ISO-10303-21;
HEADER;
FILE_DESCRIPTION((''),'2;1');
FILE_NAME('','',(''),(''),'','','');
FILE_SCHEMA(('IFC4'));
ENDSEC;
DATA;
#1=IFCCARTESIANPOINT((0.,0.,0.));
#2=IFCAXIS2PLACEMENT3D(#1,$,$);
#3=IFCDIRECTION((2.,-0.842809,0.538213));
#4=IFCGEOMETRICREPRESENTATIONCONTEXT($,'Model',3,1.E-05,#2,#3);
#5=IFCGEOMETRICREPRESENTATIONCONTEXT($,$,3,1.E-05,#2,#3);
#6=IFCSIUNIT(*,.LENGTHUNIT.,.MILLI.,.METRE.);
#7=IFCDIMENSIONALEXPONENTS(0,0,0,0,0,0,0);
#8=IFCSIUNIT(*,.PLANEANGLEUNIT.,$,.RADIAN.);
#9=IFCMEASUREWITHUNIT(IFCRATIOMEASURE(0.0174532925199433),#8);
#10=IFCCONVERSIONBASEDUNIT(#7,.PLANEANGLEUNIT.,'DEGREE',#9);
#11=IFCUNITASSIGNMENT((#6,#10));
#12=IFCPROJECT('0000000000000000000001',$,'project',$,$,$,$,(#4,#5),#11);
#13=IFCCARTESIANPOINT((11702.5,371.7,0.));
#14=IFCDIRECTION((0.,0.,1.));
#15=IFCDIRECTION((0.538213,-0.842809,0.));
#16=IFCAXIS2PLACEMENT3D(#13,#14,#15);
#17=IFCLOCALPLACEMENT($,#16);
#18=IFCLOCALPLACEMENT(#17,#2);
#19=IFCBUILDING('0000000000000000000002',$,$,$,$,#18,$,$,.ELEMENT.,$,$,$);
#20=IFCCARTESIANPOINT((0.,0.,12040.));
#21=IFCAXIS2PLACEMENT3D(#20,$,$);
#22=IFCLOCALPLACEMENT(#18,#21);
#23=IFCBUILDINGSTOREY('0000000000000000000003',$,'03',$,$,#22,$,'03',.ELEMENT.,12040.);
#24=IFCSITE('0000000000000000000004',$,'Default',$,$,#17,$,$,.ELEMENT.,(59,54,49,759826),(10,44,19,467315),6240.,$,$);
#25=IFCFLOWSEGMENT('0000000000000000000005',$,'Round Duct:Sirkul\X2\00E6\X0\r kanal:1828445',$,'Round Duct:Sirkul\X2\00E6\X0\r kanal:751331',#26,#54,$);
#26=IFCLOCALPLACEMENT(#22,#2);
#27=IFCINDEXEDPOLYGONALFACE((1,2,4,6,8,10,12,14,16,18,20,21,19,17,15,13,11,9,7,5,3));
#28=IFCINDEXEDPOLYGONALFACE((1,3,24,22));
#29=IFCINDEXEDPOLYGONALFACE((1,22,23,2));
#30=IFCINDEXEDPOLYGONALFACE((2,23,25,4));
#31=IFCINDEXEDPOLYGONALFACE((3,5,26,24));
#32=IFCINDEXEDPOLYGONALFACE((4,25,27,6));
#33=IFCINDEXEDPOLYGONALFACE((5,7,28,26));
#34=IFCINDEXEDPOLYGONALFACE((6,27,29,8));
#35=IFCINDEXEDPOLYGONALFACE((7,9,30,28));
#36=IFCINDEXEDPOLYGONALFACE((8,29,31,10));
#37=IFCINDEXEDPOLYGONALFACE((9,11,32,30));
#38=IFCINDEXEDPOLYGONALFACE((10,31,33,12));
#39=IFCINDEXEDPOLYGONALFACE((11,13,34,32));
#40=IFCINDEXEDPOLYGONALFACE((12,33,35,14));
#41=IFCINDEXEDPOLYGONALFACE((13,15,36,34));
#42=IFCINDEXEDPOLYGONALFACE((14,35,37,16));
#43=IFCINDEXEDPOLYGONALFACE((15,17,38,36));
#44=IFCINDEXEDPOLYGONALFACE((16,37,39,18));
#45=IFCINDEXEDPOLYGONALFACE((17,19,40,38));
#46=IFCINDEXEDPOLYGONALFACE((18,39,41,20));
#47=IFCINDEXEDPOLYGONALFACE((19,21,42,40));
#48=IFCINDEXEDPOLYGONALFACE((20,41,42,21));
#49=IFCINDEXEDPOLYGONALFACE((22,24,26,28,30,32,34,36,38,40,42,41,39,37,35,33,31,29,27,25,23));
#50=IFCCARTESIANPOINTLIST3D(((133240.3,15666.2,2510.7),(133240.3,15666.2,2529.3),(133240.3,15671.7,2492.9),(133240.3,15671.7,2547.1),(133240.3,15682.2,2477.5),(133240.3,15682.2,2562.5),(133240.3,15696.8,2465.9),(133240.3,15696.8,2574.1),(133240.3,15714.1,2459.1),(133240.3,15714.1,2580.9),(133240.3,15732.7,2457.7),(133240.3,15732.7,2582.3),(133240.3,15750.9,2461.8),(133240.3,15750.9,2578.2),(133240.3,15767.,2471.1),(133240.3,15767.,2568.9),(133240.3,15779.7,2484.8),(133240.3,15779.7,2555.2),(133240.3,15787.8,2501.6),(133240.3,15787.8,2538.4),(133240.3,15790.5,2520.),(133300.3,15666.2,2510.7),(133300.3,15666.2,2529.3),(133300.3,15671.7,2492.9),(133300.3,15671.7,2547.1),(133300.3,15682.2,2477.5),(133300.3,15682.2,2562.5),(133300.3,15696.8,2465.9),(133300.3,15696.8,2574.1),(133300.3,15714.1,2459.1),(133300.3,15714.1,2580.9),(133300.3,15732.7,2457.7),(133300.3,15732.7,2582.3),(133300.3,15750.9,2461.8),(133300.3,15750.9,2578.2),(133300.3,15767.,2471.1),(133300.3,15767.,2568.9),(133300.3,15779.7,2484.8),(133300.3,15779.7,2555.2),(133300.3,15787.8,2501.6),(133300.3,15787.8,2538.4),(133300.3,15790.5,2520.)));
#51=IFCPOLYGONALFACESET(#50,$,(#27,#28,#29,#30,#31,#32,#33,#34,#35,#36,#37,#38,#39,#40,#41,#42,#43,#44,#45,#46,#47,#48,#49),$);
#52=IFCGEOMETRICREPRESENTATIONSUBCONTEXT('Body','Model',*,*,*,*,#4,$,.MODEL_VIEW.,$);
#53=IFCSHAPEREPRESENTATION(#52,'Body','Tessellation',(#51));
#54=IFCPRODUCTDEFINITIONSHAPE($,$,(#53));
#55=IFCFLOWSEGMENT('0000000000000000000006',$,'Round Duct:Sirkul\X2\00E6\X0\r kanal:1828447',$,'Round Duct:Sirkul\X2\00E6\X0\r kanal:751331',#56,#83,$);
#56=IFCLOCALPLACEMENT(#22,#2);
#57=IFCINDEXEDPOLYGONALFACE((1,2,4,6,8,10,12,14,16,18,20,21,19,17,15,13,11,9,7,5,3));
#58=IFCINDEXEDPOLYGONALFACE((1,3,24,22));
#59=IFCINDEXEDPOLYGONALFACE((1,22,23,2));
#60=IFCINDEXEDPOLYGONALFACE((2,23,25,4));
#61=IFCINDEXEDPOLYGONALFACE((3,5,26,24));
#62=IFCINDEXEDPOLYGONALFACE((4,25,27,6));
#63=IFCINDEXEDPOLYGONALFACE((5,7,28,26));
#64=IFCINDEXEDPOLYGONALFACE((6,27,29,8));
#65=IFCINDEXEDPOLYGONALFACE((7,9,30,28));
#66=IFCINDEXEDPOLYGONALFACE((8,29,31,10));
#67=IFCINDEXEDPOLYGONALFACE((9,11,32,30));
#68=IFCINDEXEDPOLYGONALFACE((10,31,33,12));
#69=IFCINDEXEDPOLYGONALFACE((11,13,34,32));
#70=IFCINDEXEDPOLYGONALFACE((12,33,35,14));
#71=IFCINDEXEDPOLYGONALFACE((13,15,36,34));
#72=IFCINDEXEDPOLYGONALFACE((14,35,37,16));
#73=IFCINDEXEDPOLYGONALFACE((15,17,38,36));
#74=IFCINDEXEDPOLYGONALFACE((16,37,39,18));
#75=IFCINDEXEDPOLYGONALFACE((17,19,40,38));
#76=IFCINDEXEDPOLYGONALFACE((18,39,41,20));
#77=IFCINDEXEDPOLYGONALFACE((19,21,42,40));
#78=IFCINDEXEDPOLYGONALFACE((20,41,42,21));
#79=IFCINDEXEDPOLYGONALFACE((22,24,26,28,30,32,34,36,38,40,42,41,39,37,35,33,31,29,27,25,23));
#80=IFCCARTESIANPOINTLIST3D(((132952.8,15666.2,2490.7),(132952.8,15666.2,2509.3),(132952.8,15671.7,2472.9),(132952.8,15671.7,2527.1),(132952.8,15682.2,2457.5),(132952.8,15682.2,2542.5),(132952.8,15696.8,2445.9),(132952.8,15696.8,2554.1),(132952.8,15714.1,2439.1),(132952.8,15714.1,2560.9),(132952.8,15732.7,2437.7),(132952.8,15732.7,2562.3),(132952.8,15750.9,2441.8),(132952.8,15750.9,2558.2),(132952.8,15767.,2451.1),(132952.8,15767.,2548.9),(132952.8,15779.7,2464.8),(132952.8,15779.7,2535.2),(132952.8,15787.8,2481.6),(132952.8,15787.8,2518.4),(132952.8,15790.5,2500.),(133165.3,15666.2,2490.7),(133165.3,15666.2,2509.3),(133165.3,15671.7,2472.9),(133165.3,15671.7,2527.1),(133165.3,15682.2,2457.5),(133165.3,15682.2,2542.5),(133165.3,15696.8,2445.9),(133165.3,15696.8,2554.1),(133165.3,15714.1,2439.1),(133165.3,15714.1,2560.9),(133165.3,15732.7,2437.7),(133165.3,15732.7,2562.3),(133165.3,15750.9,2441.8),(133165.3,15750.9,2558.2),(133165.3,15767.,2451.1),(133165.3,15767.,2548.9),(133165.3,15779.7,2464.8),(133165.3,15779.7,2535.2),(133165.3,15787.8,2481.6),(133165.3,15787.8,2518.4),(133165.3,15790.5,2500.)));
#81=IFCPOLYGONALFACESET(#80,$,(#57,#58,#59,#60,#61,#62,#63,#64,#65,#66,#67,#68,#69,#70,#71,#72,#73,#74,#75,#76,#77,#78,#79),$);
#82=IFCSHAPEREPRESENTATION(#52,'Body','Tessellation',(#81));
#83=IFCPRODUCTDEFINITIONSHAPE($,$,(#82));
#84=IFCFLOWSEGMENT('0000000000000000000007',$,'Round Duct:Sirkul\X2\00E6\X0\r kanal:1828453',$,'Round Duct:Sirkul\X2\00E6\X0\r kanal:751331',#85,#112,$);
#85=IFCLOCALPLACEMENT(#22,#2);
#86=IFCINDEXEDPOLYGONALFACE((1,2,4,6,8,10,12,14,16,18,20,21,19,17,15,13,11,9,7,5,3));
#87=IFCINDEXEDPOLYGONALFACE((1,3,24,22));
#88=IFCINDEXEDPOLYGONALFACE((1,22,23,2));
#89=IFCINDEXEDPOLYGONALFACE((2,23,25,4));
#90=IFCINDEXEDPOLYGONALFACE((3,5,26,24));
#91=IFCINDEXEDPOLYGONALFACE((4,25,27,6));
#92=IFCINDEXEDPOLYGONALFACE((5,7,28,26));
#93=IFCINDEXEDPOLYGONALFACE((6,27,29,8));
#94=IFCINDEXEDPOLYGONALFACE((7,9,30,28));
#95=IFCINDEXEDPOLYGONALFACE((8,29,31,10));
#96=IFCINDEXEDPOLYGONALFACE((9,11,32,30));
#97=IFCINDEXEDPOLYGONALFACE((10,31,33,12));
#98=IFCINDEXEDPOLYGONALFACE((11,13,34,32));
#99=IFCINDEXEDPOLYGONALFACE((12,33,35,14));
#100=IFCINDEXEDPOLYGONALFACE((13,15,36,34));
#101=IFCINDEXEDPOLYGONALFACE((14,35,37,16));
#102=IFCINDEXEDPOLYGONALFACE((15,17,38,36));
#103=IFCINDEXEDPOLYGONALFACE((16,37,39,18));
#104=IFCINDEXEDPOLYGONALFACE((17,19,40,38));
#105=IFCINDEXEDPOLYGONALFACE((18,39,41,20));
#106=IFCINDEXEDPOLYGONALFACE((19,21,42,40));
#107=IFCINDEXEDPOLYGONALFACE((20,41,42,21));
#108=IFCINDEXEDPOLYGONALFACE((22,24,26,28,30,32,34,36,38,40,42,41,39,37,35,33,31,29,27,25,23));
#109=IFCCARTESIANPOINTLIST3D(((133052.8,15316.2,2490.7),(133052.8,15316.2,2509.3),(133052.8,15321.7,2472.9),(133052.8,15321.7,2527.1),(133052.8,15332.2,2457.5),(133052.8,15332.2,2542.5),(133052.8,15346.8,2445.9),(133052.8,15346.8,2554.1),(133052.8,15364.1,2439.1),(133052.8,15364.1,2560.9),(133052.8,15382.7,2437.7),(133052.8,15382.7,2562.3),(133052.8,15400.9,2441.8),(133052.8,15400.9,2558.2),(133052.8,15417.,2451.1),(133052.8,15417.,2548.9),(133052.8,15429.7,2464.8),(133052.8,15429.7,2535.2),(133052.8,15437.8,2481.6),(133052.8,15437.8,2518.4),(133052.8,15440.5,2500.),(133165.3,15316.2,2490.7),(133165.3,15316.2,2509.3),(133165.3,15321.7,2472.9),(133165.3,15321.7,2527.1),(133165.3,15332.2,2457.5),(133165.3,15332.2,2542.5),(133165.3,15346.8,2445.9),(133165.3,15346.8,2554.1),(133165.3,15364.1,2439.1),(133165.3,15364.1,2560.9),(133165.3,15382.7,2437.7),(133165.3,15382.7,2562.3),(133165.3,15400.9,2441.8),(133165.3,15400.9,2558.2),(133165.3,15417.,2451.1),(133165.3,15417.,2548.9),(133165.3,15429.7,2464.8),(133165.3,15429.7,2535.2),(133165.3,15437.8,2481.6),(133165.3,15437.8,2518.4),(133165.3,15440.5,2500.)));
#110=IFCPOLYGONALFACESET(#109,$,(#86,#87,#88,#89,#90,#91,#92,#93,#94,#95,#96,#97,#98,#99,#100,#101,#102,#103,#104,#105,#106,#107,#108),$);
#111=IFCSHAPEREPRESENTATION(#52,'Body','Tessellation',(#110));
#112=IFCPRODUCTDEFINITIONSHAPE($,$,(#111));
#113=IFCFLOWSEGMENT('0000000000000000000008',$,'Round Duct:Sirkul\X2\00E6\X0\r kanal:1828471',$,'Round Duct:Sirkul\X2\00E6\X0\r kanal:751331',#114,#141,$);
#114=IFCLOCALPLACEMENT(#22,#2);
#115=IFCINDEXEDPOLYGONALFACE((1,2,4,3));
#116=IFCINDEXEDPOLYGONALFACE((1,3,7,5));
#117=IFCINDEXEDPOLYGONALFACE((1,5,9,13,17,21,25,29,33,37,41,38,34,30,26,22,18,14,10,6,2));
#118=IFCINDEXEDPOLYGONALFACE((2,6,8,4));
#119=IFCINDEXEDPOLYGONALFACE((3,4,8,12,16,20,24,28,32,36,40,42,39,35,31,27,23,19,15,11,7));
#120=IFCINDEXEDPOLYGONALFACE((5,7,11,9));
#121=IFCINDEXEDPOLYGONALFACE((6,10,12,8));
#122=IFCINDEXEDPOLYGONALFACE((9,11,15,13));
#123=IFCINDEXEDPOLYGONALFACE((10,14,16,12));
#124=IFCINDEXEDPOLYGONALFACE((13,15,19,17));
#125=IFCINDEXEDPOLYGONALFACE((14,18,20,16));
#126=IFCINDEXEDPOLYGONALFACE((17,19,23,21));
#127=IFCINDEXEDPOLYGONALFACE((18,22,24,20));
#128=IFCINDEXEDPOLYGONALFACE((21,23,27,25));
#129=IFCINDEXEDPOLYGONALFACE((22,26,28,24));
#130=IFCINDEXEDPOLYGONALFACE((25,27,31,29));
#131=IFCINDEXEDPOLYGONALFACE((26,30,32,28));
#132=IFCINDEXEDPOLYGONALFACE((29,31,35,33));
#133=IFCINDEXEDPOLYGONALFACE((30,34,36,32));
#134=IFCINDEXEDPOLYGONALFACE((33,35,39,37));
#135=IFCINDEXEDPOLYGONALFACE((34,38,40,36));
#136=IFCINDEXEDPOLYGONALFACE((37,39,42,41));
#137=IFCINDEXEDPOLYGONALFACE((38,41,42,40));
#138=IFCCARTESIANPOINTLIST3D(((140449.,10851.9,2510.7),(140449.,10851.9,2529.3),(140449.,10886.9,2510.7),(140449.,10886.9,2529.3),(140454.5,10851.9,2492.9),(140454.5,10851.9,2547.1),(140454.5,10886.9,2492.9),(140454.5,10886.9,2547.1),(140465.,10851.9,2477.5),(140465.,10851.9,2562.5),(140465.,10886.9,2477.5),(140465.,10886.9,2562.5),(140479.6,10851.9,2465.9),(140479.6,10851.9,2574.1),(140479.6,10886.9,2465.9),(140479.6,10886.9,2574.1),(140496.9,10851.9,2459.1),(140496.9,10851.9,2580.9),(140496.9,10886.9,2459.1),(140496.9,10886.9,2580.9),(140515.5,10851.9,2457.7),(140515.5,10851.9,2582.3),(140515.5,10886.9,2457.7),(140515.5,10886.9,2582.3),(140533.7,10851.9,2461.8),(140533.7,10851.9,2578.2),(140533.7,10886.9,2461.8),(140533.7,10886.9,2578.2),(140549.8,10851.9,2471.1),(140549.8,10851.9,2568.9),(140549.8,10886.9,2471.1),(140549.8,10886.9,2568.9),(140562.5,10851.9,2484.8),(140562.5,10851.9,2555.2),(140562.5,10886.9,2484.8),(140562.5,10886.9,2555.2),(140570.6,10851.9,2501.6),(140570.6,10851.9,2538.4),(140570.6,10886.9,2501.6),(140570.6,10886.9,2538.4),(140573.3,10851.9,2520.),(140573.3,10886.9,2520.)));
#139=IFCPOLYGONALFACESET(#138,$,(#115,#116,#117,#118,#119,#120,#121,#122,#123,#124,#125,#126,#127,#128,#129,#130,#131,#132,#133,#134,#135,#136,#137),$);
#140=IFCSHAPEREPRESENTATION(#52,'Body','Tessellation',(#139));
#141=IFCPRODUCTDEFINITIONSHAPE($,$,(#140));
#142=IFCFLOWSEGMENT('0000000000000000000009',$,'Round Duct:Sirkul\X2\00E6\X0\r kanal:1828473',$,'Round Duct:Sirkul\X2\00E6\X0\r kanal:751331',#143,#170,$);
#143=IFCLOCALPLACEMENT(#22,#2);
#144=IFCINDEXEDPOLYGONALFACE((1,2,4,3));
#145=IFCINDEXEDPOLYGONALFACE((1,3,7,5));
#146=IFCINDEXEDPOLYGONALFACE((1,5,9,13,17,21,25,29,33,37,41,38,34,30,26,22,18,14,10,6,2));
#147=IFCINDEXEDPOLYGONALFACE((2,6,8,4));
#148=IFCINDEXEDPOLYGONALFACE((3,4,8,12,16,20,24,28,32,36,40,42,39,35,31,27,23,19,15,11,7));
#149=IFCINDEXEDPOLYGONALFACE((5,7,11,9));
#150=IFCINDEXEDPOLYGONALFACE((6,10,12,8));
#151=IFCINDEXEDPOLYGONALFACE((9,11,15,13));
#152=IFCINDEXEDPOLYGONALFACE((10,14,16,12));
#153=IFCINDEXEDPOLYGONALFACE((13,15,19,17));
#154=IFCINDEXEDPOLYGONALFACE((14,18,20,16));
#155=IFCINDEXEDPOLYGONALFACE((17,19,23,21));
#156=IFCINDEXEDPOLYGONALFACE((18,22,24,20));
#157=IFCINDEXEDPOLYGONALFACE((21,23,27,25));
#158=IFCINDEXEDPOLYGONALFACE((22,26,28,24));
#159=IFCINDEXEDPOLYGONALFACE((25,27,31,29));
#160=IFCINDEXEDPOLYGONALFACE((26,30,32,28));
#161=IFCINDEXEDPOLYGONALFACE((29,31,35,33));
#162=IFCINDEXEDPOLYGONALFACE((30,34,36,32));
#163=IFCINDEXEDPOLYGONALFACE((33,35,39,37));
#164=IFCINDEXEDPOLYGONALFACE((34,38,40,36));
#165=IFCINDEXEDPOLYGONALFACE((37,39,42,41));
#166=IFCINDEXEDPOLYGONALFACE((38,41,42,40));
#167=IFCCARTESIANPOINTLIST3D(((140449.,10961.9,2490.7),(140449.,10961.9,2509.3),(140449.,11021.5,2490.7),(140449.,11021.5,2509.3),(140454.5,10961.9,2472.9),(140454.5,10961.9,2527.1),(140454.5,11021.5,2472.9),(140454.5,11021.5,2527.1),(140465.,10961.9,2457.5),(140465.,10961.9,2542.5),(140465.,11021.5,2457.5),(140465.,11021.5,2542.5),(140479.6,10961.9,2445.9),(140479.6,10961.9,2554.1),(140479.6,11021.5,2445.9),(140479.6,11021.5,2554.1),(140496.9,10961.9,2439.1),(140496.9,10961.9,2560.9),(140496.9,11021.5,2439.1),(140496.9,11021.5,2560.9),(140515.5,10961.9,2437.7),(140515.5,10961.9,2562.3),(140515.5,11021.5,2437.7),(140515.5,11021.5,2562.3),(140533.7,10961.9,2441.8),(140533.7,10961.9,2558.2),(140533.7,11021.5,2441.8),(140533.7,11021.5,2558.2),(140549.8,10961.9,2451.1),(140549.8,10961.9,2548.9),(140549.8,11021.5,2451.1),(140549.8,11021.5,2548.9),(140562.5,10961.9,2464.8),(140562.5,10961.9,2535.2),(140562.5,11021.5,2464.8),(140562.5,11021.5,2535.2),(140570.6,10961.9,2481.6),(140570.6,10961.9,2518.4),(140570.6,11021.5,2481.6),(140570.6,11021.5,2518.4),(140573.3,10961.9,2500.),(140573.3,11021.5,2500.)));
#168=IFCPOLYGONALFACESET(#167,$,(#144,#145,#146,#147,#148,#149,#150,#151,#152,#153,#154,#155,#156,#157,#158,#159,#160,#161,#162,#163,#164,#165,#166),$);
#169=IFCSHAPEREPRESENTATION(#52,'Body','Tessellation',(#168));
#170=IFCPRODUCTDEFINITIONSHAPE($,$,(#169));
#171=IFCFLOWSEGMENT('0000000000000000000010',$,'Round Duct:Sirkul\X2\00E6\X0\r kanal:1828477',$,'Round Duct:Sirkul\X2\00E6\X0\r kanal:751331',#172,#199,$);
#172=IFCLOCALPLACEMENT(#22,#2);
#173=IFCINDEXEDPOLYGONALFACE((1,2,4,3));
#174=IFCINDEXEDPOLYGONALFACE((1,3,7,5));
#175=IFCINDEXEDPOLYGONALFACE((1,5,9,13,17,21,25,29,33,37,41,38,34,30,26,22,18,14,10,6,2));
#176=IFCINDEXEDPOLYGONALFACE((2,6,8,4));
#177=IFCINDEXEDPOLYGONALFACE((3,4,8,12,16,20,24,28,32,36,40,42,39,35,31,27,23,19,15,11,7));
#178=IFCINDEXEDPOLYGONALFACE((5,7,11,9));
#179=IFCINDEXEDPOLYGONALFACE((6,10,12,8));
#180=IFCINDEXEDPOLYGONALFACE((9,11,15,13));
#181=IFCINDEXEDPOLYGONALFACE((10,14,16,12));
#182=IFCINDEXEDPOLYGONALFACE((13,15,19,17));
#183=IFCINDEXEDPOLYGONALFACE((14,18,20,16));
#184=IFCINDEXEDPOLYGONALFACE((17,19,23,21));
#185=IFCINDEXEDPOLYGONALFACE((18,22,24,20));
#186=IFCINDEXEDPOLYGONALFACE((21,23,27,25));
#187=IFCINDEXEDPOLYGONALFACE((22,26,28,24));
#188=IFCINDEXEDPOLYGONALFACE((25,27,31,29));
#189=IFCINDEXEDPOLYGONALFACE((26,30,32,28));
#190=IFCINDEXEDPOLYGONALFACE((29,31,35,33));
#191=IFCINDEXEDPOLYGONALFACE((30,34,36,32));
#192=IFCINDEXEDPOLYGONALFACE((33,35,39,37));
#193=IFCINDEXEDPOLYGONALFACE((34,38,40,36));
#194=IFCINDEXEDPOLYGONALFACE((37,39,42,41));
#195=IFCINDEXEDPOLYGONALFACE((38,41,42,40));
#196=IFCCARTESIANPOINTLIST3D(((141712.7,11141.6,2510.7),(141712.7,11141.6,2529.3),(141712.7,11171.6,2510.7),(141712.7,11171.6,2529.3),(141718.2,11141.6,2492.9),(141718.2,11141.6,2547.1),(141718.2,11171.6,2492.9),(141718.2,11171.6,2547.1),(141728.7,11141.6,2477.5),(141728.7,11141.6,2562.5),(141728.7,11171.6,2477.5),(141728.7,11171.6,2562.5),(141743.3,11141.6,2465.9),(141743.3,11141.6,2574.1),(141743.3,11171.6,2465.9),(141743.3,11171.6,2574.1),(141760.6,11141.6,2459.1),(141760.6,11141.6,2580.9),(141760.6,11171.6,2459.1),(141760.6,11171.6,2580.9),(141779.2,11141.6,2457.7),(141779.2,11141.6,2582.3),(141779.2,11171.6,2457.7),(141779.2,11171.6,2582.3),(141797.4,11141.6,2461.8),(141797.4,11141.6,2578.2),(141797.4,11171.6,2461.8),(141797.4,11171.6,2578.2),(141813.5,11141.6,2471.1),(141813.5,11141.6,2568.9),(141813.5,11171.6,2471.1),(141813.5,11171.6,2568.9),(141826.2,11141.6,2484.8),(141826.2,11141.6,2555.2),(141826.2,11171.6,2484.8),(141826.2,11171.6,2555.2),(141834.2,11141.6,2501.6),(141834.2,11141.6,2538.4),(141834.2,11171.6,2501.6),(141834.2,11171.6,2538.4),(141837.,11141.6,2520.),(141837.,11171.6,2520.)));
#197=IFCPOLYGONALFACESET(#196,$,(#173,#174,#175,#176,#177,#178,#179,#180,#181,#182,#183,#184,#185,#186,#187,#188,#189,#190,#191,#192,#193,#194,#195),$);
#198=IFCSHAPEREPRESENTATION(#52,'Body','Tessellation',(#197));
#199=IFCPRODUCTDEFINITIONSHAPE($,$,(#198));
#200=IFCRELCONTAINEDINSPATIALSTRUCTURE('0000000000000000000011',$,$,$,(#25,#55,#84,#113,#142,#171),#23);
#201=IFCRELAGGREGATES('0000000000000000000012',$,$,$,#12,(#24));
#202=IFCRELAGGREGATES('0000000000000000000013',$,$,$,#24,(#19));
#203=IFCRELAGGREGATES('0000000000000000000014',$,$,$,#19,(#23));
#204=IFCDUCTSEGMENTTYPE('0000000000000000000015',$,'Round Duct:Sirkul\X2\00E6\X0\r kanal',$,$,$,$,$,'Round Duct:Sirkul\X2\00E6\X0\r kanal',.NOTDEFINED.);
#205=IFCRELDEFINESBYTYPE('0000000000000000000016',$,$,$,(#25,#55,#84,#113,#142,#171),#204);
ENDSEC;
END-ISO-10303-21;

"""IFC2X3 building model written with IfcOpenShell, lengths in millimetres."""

from ifc_helpers import new_model, entity, si_unit, converted_unit, direction, frame, frame_2d, origin, origin_2d_with_axis, place, context, subcontext, project, spatial, circle, extrude, type_object, element, save


model = new_model("IFC2X3")

# Units and contexts
model_context = context("Model", 3, precision=1e-05, world=origin(), true_north=direction((2.0, -0.842809, 0.538213)))
context_of_model = context(None, 3, precision=1e-05, world=origin(), true_north=direction((2.0, -0.842809, 0.538213)))
body_context = subcontext(model_context, "Body", "Model", "MODEL_VIEW")
ifc_project = project(units=[si_unit("LENGTHUNIT", "METRE", prefix="MILLI"), converted_unit("PLANEANGLEUNIT", "DEGREE", entity("IfcRatioMeasure", 0.0174532925199433), si_unit("PLANEANGLEUNIT", "RADIAN"), dimensions=[0, 0, 0, 0, 0, 0, 0])], contexts=[model_context, context_of_model])

# Site, building, storey
site_placement = place(None, frame((11702.5, 371.7, 0.0), z_axis=(0.0, 0.0, 1.0), x_axis=(0.538213, -0.842809, 0.0)))
site = spatial("IfcSite", under=ifc_project, at=site_placement, Name="Default", CompositionType="ELEMENT", RefLatitude=(59, 54, 49, 759826), RefLongitude=(10, 44, 19, 467315), RefElevation=6240.0)
building_placement = place(site_placement, origin())
building = spatial("IfcBuilding", under=site, at=building_placement, CompositionType="ELEMENT")
storey_placement = place(building_placement, frame((0.0, 0.0, 12040.0)))
storey = spatial("IfcBuildingStorey", under=building, at=storey_placement, Name="03", LongName="03", CompositionType="ELEMENT", Elevation=12040.0)

# Flow segments
duct_segment_type_1 = type_object("IfcDuctSegmentType", Name="Round Duct:Sirkulær kanal", ElementType="Round Duct:Sirkulær kanal", PredefinedType="NOTDEFINED")
flow_segment_1_placement = place(storey_placement, origin())
element("IfcFlowSegment", 1, at=flow_segment_1_placement, inside=storey, type_object=duct_segment_type_1, Name="Round Duct:Sirkulær kanal:1828445", ObjectType="Round Duct:Sirkulær kanal:751331", context=body_context, shape_type="SweptSolid", body=[
    extrude(circle(Radius=62.5, at=frame_2d((0.0, 0.0), x_axis=(1.0, 0.0))), frame((133240.3, 15728.0, 2520.0), z_axis=(1.0, 0.0, 0.0), x_axis=(0.0, 1.0, 0.0)), (0.0, 0.0, 1.0), 60.0),
])
flow_segment_2_placement = place(storey_placement, origin())
element("IfcFlowSegment", 2, at=flow_segment_2_placement, inside=storey, type_object=duct_segment_type_1, Name="Round Duct:Sirkulær kanal:1828447", ObjectType="Round Duct:Sirkulær kanal:751331", context=body_context, shape_type="SweptSolid", body=[
    extrude(circle(Radius=62.5, at=frame_2d((0.0, 0.0), x_axis=(1.0, 0.0))), frame((132952.8, 15728.0, 2500.0), z_axis=(1.0, 0.0, 0.0), x_axis=(0.0, 1.0, 0.0)), (0.0, 0.0, 1.0), 212.5),
])
flow_segment_3_placement = place(storey_placement, origin())
element("IfcFlowSegment", 3, at=flow_segment_3_placement, inside=storey, type_object=duct_segment_type_1, Name="Round Duct:Sirkulær kanal:1828453", ObjectType="Round Duct:Sirkulær kanal:751331", context=body_context, shape_type="SweptSolid", body=[
    extrude(circle(Radius=62.5, at=frame_2d((0.0, 0.0), x_axis=(1.0, 0.0))), frame((133052.8, 15378.0, 2500.0), z_axis=(1.0, 0.0, 0.0), x_axis=(0.0, 1.0, 0.0)), (0.0, 0.0, 1.0), 112.5),
])
flow_segment_4_placement = place(storey_placement, origin())
element("IfcFlowSegment", 4, at=flow_segment_4_placement, inside=storey, type_object=duct_segment_type_1, Name="Round Duct:Sirkulær kanal:1828471", ObjectType="Round Duct:Sirkulær kanal:751331", context=body_context, shape_type="SweptSolid", body=[
    extrude(circle(Radius=62.5, at=frame_2d((0.0, 0.0), x_axis=(1.0, 0.0))), frame((140510.8, 10851.9, 2520.0), z_axis=(0.0, 1.0, 0.0), x_axis=(1.0, 0.0, 0.0)), (0.0, 0.0, 1.0), 35.0),
])
flow_segment_5_placement = place(storey_placement, origin())
element("IfcFlowSegment", 5, at=flow_segment_5_placement, inside=storey, type_object=duct_segment_type_1, Name="Round Duct:Sirkulær kanal:1828473", ObjectType="Round Duct:Sirkulær kanal:751331", context=body_context, shape_type="SweptSolid", body=[
    extrude(circle(Radius=62.5, at=origin_2d_with_axis()), frame((140510.8, 10961.9, 2500.0), z_axis=(0.0, 1.0, 0.0), x_axis=(1.0, 0.0, 0.0)), (0.0, 0.0, 1.0), 59.6),
])
flow_segment_6_placement = place(storey_placement, origin())
element("IfcFlowSegment", 6, at=flow_segment_6_placement, inside=storey, type_object=duct_segment_type_1, Name="Round Duct:Sirkulær kanal:1828477", ObjectType="Round Duct:Sirkulær kanal:751331", context=body_context, shape_type="SweptSolid", body=[
    extrude(circle(Radius=62.5, at=frame_2d((0.0, 0.0), x_axis=(1.0, 0.0))), frame((141774.5, 11141.6, 2520.0), z_axis=(0.0, 1.0, 0.0), x_axis=(1.0, 0.0, 0.0)), (0.0, 0.0, 1.0), 30.0),
])

save(model, "model.ifc")
